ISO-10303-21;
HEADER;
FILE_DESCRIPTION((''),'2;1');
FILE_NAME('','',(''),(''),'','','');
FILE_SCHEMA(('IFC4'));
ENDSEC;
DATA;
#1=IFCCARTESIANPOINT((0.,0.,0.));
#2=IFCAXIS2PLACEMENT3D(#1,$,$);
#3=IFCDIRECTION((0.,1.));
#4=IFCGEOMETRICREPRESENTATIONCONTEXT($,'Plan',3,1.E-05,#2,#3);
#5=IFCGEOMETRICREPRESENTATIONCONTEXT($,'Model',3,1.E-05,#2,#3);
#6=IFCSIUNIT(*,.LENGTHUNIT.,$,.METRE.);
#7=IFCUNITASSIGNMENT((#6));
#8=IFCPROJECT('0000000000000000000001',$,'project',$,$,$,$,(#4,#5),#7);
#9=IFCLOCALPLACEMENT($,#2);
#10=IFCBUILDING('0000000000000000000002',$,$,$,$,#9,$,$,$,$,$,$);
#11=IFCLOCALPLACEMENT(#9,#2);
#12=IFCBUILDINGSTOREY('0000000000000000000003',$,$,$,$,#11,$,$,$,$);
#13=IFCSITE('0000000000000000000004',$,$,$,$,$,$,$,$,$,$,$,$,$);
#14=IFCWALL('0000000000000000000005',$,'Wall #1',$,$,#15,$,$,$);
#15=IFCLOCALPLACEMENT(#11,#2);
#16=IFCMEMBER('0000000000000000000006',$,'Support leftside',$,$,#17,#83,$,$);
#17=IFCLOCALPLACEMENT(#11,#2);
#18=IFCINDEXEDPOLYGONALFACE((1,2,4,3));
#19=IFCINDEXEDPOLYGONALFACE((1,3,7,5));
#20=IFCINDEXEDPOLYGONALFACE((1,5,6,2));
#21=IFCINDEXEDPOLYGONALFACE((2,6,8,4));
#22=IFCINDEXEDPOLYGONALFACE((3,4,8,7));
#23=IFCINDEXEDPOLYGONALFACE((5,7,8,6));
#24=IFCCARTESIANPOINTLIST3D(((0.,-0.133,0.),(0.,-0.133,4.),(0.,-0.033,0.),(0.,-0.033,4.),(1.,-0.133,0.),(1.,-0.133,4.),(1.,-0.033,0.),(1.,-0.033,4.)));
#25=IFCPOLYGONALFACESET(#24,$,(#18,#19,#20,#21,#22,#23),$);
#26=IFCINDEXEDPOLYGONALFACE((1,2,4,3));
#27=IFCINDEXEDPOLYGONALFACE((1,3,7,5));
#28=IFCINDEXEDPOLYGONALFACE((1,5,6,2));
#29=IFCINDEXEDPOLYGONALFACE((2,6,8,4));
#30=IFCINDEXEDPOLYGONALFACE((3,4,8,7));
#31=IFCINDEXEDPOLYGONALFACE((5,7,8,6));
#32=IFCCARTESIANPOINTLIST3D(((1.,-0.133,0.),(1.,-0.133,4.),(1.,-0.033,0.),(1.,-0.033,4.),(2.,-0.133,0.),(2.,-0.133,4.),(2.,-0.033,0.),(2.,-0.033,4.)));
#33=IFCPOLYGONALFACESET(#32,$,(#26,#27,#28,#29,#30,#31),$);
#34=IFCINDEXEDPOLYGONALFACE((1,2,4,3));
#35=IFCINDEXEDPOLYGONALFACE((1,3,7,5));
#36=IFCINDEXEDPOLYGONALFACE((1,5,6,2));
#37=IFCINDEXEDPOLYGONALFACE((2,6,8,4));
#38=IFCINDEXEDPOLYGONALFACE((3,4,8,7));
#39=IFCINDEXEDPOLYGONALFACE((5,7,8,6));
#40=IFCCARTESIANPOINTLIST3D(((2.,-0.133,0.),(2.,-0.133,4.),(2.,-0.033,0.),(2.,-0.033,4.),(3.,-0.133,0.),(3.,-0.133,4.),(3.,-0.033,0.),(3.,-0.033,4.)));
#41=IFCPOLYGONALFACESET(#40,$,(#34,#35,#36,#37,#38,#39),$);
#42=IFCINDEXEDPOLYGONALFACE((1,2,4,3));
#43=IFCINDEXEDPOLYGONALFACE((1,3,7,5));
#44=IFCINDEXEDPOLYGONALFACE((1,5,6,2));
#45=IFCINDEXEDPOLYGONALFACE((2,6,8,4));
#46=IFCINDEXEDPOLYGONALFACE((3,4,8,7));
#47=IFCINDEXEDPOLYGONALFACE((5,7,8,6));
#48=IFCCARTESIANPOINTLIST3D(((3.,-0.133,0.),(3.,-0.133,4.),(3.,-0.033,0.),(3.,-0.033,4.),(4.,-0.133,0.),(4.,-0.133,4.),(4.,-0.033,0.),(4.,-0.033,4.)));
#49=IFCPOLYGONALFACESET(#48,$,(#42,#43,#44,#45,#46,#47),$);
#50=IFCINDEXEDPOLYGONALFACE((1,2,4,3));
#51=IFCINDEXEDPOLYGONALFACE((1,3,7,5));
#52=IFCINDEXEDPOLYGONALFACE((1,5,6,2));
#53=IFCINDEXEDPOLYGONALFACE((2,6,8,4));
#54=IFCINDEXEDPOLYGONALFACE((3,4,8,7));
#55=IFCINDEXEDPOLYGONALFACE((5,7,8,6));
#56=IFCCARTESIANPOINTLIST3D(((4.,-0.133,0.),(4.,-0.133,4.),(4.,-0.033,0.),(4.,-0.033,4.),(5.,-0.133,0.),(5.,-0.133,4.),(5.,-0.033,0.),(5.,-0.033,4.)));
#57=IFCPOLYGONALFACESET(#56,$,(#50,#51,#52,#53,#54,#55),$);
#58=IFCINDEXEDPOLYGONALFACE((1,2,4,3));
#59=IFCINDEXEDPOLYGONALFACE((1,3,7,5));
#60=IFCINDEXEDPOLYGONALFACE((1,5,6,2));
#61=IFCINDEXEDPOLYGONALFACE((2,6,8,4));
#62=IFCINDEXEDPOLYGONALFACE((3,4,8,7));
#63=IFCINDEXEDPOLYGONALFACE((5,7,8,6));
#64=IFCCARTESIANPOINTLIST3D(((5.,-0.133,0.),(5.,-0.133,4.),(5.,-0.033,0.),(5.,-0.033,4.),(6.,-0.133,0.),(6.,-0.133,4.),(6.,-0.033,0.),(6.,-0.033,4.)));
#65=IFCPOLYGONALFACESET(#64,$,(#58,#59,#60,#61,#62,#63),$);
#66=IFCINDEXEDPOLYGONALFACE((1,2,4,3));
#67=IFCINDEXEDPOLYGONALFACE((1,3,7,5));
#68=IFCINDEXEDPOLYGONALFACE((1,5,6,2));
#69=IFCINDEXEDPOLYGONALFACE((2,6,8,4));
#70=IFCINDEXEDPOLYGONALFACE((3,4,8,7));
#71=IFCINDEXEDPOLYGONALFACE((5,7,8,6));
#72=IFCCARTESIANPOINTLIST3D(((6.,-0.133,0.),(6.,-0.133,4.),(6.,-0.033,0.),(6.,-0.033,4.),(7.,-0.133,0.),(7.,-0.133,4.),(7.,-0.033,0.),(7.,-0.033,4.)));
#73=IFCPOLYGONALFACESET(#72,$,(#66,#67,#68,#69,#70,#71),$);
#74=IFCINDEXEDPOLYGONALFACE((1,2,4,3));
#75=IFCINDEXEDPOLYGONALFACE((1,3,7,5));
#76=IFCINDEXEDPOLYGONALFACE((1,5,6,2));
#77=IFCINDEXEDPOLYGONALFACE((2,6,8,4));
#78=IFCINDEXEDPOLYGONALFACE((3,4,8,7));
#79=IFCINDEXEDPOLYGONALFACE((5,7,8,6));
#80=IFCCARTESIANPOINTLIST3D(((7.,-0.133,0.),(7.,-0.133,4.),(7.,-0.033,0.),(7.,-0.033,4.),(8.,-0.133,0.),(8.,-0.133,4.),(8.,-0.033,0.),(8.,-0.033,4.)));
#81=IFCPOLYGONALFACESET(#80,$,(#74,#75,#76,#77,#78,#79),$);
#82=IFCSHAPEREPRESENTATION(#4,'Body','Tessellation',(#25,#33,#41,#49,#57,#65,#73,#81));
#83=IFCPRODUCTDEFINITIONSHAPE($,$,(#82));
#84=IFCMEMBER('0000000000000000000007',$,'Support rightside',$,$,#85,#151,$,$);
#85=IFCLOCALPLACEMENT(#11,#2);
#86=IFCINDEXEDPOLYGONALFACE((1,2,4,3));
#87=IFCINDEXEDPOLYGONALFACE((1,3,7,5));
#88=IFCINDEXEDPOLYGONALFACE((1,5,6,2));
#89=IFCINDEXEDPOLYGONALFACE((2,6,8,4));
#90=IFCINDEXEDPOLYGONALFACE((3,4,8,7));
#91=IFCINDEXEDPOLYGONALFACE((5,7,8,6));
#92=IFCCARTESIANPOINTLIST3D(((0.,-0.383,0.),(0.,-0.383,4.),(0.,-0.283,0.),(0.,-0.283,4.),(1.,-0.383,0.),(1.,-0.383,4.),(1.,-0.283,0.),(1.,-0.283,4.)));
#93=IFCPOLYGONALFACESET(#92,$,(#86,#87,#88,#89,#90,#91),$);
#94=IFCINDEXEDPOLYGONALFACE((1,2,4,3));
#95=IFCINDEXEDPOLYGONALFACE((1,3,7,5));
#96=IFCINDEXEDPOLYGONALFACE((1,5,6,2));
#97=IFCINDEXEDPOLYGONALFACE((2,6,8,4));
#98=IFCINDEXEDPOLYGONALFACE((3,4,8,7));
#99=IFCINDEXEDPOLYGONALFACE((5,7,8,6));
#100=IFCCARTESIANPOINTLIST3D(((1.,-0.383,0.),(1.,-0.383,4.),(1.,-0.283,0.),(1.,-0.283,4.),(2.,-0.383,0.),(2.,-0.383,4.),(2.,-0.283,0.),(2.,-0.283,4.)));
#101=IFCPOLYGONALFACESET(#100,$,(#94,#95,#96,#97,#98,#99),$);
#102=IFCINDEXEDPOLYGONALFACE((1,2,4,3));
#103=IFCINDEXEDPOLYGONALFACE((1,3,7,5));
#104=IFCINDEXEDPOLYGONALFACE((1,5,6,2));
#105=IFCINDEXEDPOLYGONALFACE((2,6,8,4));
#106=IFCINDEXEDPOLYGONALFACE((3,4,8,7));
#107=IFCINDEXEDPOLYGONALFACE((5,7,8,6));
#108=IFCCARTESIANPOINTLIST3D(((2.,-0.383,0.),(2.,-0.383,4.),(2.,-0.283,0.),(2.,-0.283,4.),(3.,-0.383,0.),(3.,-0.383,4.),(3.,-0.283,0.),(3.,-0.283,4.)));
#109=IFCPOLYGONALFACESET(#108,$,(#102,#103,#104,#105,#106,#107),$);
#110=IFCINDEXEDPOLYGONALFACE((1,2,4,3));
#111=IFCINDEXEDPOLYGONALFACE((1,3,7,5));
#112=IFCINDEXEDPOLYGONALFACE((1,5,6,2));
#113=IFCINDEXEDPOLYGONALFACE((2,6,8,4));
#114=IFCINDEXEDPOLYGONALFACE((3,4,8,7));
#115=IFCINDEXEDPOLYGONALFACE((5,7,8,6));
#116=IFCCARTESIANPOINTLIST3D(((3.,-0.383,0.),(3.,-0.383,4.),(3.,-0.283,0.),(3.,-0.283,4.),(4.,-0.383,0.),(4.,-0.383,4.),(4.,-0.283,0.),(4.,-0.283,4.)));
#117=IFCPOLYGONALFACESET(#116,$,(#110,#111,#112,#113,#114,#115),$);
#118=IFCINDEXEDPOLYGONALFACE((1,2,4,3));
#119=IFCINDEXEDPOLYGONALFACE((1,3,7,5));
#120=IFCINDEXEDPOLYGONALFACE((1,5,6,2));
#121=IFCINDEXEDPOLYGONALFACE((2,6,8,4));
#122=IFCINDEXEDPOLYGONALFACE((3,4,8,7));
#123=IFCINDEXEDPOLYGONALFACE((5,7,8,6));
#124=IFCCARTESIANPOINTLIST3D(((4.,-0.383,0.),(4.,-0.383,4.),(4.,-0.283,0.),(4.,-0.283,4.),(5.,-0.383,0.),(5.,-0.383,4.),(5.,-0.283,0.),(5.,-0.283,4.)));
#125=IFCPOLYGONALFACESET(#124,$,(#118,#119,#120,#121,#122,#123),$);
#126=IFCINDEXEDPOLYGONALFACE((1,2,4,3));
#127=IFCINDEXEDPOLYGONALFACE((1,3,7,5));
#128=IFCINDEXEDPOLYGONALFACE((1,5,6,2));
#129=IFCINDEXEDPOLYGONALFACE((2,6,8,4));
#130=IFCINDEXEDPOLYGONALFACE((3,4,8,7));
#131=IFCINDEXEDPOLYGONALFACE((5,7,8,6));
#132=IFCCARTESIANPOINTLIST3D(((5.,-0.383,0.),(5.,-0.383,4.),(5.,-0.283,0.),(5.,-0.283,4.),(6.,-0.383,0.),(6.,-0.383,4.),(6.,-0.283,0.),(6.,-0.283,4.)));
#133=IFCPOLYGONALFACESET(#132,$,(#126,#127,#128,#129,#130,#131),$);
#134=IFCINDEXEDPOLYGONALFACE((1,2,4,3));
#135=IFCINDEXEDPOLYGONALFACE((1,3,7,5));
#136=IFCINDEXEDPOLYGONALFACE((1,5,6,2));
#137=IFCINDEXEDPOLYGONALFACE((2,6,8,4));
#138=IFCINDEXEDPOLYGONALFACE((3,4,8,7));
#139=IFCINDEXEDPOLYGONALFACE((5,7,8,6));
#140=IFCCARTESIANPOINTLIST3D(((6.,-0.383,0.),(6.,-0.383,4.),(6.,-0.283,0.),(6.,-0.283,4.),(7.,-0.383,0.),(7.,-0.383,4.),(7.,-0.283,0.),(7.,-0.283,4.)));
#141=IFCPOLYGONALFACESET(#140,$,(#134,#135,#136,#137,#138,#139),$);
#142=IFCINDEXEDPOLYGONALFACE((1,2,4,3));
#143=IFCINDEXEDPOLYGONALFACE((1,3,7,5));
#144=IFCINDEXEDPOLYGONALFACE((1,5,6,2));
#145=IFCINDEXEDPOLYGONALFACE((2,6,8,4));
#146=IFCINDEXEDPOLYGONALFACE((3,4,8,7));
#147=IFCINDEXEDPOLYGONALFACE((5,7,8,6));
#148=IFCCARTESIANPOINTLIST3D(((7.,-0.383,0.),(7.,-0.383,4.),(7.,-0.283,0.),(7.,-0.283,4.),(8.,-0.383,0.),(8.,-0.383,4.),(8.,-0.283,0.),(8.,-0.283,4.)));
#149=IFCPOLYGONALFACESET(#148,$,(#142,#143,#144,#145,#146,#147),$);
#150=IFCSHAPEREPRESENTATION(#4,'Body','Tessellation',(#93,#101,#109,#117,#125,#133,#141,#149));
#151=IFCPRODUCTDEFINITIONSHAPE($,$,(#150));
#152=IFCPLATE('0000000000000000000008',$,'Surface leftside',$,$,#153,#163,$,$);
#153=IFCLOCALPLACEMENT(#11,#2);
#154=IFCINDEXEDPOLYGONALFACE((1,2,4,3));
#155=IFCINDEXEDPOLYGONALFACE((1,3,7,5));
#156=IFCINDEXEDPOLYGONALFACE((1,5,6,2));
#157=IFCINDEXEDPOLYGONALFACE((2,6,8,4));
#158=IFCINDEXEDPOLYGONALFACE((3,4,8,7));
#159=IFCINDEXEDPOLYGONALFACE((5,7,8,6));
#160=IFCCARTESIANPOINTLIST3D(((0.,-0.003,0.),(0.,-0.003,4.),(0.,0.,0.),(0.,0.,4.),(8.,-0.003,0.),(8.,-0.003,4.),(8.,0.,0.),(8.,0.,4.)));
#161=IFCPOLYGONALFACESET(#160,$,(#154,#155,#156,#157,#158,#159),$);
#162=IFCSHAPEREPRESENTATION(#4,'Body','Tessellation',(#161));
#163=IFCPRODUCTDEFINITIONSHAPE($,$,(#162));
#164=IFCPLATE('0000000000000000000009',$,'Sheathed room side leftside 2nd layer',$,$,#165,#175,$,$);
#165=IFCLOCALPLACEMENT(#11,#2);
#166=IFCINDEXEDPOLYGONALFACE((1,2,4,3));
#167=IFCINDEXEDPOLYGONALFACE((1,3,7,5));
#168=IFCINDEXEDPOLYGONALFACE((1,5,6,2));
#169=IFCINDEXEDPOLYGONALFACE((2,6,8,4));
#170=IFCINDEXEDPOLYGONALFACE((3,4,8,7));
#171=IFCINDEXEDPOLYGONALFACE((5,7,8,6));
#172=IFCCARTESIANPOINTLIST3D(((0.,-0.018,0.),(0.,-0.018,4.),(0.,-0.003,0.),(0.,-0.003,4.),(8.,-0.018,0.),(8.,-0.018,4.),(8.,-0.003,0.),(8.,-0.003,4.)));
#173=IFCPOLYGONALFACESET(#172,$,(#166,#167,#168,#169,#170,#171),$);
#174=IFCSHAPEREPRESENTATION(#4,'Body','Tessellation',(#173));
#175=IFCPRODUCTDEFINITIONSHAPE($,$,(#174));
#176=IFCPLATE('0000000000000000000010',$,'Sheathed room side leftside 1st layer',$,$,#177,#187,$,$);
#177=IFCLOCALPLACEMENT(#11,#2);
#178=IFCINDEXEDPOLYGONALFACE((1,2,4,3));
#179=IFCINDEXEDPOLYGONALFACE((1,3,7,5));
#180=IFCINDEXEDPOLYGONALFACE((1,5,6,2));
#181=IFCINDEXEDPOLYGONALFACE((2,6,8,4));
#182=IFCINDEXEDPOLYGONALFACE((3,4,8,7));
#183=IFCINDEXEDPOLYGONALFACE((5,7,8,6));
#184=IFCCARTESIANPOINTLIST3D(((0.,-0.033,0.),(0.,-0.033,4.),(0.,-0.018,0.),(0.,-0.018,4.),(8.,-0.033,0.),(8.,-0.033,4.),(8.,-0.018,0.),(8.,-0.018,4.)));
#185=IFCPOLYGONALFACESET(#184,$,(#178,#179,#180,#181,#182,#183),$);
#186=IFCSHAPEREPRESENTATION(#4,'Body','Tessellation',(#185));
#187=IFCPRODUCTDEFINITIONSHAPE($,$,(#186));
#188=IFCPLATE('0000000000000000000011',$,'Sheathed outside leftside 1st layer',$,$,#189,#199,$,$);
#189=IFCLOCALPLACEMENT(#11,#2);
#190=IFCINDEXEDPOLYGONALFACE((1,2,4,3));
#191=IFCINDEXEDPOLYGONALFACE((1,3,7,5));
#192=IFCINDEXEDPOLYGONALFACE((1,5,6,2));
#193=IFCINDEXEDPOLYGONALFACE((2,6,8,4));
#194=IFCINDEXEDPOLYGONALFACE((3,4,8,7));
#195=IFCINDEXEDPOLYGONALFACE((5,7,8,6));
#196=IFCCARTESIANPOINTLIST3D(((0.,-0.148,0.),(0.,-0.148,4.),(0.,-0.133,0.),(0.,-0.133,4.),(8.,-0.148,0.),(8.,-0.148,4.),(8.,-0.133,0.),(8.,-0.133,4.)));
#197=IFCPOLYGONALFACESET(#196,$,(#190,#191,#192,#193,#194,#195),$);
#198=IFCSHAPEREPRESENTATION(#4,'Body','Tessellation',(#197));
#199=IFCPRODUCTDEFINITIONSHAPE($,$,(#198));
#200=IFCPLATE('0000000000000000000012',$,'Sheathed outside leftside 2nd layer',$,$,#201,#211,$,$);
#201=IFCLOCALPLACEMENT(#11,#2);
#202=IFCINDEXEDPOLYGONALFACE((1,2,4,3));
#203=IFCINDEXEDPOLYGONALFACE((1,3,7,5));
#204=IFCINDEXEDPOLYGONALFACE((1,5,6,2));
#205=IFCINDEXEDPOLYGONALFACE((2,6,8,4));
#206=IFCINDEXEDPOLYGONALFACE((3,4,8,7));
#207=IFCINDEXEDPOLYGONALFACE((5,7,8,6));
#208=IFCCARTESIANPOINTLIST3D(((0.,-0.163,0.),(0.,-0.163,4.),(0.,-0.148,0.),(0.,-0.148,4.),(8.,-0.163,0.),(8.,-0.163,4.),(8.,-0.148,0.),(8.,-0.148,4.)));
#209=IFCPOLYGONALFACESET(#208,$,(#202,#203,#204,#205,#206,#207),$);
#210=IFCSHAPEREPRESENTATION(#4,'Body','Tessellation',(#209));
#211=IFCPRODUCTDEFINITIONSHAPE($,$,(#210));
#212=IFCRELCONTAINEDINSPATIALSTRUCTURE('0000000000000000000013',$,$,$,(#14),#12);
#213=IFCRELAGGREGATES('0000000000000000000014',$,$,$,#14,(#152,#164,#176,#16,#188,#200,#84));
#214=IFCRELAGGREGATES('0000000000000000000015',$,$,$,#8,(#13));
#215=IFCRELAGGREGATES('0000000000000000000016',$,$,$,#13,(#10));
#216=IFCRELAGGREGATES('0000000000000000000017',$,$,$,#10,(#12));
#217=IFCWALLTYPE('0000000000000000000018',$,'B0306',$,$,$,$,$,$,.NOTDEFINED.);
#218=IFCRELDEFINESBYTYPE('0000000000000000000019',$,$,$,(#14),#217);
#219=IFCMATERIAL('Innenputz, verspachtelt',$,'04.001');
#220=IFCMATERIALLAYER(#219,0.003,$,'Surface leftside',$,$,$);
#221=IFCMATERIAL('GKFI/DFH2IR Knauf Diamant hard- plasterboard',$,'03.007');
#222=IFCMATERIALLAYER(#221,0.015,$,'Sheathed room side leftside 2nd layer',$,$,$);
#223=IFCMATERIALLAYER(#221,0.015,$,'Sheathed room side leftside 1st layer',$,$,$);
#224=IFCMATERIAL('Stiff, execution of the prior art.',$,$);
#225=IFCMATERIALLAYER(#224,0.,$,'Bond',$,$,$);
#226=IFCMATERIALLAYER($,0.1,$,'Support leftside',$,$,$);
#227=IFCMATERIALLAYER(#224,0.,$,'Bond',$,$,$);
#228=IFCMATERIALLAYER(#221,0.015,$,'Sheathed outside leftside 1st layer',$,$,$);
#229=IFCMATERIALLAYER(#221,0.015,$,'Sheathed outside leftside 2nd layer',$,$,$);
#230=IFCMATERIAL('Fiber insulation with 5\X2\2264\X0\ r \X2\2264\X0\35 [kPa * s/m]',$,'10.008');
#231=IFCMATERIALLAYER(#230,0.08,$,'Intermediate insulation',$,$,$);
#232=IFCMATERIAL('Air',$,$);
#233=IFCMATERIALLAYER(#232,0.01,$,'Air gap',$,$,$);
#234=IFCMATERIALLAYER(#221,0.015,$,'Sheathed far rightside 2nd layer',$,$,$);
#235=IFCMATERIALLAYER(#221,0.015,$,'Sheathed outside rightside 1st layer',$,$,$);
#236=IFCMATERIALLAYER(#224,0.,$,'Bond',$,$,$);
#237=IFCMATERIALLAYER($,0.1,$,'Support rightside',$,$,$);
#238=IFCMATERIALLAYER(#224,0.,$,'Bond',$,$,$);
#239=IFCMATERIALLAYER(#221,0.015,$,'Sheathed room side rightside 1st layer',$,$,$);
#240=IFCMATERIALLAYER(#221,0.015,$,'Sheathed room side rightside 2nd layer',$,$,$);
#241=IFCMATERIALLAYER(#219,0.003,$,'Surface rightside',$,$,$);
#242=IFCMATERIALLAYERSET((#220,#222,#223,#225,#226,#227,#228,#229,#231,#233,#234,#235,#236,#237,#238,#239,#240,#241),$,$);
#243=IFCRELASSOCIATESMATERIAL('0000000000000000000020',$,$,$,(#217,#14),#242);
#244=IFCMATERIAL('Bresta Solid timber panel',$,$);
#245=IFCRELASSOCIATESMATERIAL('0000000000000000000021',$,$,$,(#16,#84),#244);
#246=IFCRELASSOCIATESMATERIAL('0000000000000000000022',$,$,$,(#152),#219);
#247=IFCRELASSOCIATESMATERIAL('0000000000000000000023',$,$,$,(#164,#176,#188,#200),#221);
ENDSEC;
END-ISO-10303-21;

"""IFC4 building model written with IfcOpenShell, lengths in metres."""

from ifc_helpers import new_model, si_unit, direction, frame, frame_2d, origin, origin_with_axes, place, context, project, spatial, rectangle, extrude, material, layer, layer_set, type_object, element, aggregate, save


model = new_model("IFC4")

# Units and contexts
plan_context = context("Plan", 3, precision=1e-05, world=origin(), true_north=direction((0.0, 1.0)))
model_context = context("Model", 3, precision=1e-05, world=origin(), true_north=direction((0.0, 1.0)))
ifc_project = project(units=[si_unit("LENGTHUNIT", "METRE")], contexts=[plan_context, model_context])

# Site, building, storey
site = spatial("IfcSite", under=ifc_project)
building_placement = place(None, origin())
building = spatial("IfcBuilding", under=site, at=building_placement)
storey_placement = place(building_placement, origin())
storey = spatial("IfcBuildingStorey", under=building, at=storey_placement)

# Wall, members, plates
ifc_material_1 = material(Name="Innenputz, verspachtelt", Category="04.001")
ifc_layer_1 = layer(ifc_material_1, 0.003, Name="Surface leftside")
ifc_material_2 = material(Name="GKFI/DFH2IR Knauf Diamant hard- plasterboard", Category="03.007")
ifc_layer_2 = layer(ifc_material_2, 0.015, Name="Sheathed room side leftside 2nd layer")
ifc_layer_3 = layer(ifc_material_2, 0.015, Name="Sheathed room side leftside 1st layer")
ifc_material_3 = material(Name="Stiff, execution of the prior art.")
ifc_layer_4 = layer(ifc_material_3, 0.0, Name="Bond")
ifc_layer_5 = layer(None, 0.1, Name="Support leftside")
ifc_layer_6 = layer(ifc_material_3, 0.0, Name="Bond")
ifc_layer_7 = layer(ifc_material_2, 0.015, Name="Sheathed outside leftside 1st layer")
ifc_layer_8 = layer(ifc_material_2, 0.015, Name="Sheathed outside leftside 2nd layer")
ifc_material_4 = material(Name="Fiber insulation with 5≤ r ≤35 [kPa * s/m]", Category="10.008")
ifc_layer_9 = layer(ifc_material_4, 0.08, Name="Intermediate insulation")
ifc_material_5 = material(Name="Air")
ifc_layer_10 = layer(ifc_material_5, 0.01, Name="Air gap")
ifc_layer_11 = layer(ifc_material_2, 0.015, Name="Sheathed far rightside 2nd layer")
ifc_layer_12 = layer(ifc_material_2, 0.015, Name="Sheathed outside rightside 1st layer")
ifc_layer_13 = layer(ifc_material_3, 0.0, Name="Bond")
ifc_layer_14 = layer(None, 0.1, Name="Support rightside")
ifc_layer_15 = layer(ifc_material_3, 0.0, Name="Bond")
ifc_layer_16 = layer(ifc_material_2, 0.015, Name="Sheathed room side rightside 1st layer")
ifc_layer_17 = layer(ifc_material_2, 0.015, Name="Sheathed room side rightside 2nd layer")
ifc_layer_18 = layer(ifc_material_1, 0.003, Name="Surface rightside")
ifc_layer_set = layer_set([ifc_layer_1, ifc_layer_2, ifc_layer_3, ifc_layer_4, ifc_layer_5, ifc_layer_6, ifc_layer_7, ifc_layer_8, ifc_layer_9, ifc_layer_10, ifc_layer_11, ifc_layer_12, ifc_layer_13, ifc_layer_14, ifc_layer_15, ifc_layer_16, ifc_layer_17, ifc_layer_18])
wall_type = type_object("IfcWallType", Name="B0306", PredefinedType="NOTDEFINED", material=ifc_layer_set)
wall_placement = place(None, frame((0.0, 0.0, 0.0), z_axis=(0.0, -1.0, 0.0), x_axis=(1.0, 0.0, 0.0)))
wall = element("IfcWall", 1, at=wall_placement, inside=storey, type_object=wall_type, material=ifc_layer_set, Name="Wall #1")
ifc_material_6 = material(Name="Bresta Solid timber panel")
member_1_placement = place(wall_placement, origin())
member_1 = element("IfcMember", 2, at=member_1_placement, material=ifc_material_6, Name="Support leftside", context=plan_context, shape_type="SweptSolid", body=[
    extrude(rectangle(XDim=1.0, YDim=0.1, at=frame_2d((0.5, 0.05), x_axis=(1.0, 0.0))), frame((0.0, 4.0, 0.033), z_axis=(0.0, -1.0, 0.0), x_axis=(1.0, 0.0, 0.0)), (0.0, 0.0, 1.0), 4.0),
    extrude(rectangle(XDim=1.0, YDim=0.1, at=frame_2d((0.5, 0.05), x_axis=(1.0, 0.0))), frame((1.0, 4.0, 0.033), z_axis=(0.0, -1.0, 0.0), x_axis=(1.0, 0.0, 0.0)), (0.0, 0.0, 1.0), 4.0),
    extrude(rectangle(XDim=1.0, YDim=0.1, at=frame_2d((0.5, 0.05), x_axis=(1.0, 0.0))), frame((2.0, 4.0, 0.033), z_axis=(0.0, -1.0, 0.0), x_axis=(1.0, 0.0, 0.0)), (0.0, 0.0, 1.0), 4.0),
    extrude(rectangle(XDim=1.0, YDim=0.1, at=frame_2d((0.5, 0.05), x_axis=(1.0, 0.0))), frame((3.0, 4.0, 0.033), z_axis=(0.0, -1.0, 0.0), x_axis=(1.0, 0.0, 0.0)), (0.0, 0.0, 1.0), 4.0),
    extrude(rectangle(XDim=1.0, YDim=0.1, at=frame_2d((0.5, 0.05), x_axis=(1.0, 0.0))), frame((4.0, 4.0, 0.033), z_axis=(0.0, -1.0, 0.0), x_axis=(1.0, 0.0, 0.0)), (0.0, 0.0, 1.0), 4.0),
    extrude(rectangle(XDim=1.0, YDim=0.1, at=frame_2d((0.5, 0.05), x_axis=(1.0, 0.0))), frame((5.0, 4.0, 0.033), z_axis=(0.0, -1.0, 0.0), x_axis=(1.0, 0.0, 0.0)), (0.0, 0.0, 1.0), 4.0),
    extrude(rectangle(XDim=1.0, YDim=0.1, at=frame_2d((0.5, 0.05), x_axis=(1.0, 0.0))), frame((6.0, 4.0, 0.033), z_axis=(0.0, -1.0, 0.0), x_axis=(1.0, 0.0, 0.0)), (0.0, 0.0, 1.0), 4.0),
    extrude(rectangle(XDim=1.0, YDim=0.1, at=frame_2d((0.5, 0.05), x_axis=(1.0, 0.0))), frame((7.0, 4.0, 0.033), z_axis=(0.0, -1.0, 0.0), x_axis=(1.0, 0.0, 0.0)), (0.0, 0.0, 1.0), 4.0),
])
member_2_placement = place(wall_placement, origin())
member_2 = element("IfcMember", 3, at=member_2_placement, material=ifc_material_6, Name="Support rightside", context=plan_context, shape_type="SweptSolid", body=[
    extrude(rectangle(XDim=1.0, YDim=0.1, at=frame_2d((0.5, 0.05), x_axis=(1.0, 0.0))), frame((0.0, 4.0, 0.283), z_axis=(0.0, -1.0, 0.0), x_axis=(1.0, 0.0, 0.0)), (0.0, 0.0, 1.0), 4.0),
    extrude(rectangle(XDim=1.0, YDim=0.1, at=frame_2d((0.5, 0.05), x_axis=(1.0, 0.0))), frame((1.0, 4.0, 0.283), z_axis=(0.0, -1.0, 0.0), x_axis=(1.0, 0.0, 0.0)), (0.0, 0.0, 1.0), 4.0),
    extrude(rectangle(XDim=1.0, YDim=0.1, at=frame_2d((0.5, 0.05), x_axis=(1.0, 0.0))), frame((2.0, 4.0, 0.283), z_axis=(0.0, -1.0, 0.0), x_axis=(1.0, 0.0, 0.0)), (0.0, 0.0, 1.0), 4.0),
    extrude(rectangle(XDim=1.0, YDim=0.1, at=frame_2d((0.5, 0.05), x_axis=(1.0, 0.0))), frame((3.0, 4.0, 0.283), z_axis=(0.0, -1.0, 0.0), x_axis=(1.0, 0.0, 0.0)), (0.0, 0.0, 1.0), 4.0),
    extrude(rectangle(XDim=1.0, YDim=0.1, at=frame_2d((0.5, 0.05), x_axis=(1.0, 0.0))), frame((4.0, 4.0, 0.283), z_axis=(0.0, -1.0, 0.0), x_axis=(1.0, 0.0, 0.0)), (0.0, 0.0, 1.0), 4.0),
    extrude(rectangle(XDim=1.0, YDim=0.1, at=frame_2d((0.5, 0.05), x_axis=(1.0, 0.0))), frame((5.0, 4.0, 0.283), z_axis=(0.0, -1.0, 0.0), x_axis=(1.0, 0.0, 0.0)), (0.0, 0.0, 1.0), 4.0),
    extrude(rectangle(XDim=1.0, YDim=0.1, at=frame_2d((0.5, 0.05), x_axis=(1.0, 0.0))), frame((6.0, 4.0, 0.283), z_axis=(0.0, -1.0, 0.0), x_axis=(1.0, 0.0, 0.0)), (0.0, 0.0, 1.0), 4.0),
    extrude(rectangle(XDim=1.0, YDim=0.1, at=frame_2d((0.5, 0.05), x_axis=(1.0, 0.0))), frame((7.0, 4.0, 0.283), z_axis=(0.0, -1.0, 0.0), x_axis=(1.0, 0.0, 0.0)), (0.0, 0.0, 1.0), 4.0),
])
plate_1_placement = place(wall_placement, origin())
plate_1 = element("IfcPlate", 4, at=plate_1_placement, material=ifc_material_1, Name="Surface leftside", context=plan_context, shape_type="SweptSolid", body=[
    extrude(rectangle(XDim=8.0, YDim=4.0, at=frame_2d((4.0, 2.0), x_axis=(1.0, 0.0))), origin_with_axes(), (0.0, 0.0, 1.0), 0.003),
])
plate_2_placement = place(wall_placement, origin())
plate_2 = element("IfcPlate", 5, at=plate_2_placement, material=ifc_material_2, Name="Sheathed room side leftside 2nd layer", context=plan_context, shape_type="SweptSolid", body=[
    extrude(rectangle(XDim=8.0, YDim=4.0, at=frame_2d((4.0, 2.0), x_axis=(1.0, 0.0))), frame((0.0, 0.0, 0.003), z_axis=(0.0, 0.0, 1.0), x_axis=(1.0, 0.0, 0.0)), (0.0, 0.0, 1.0), 0.015),
])
plate_3_placement = place(wall_placement, origin())
plate_3 = element("IfcPlate", 6, at=plate_3_placement, material=ifc_material_2, Name="Sheathed room side leftside 1st layer", context=plan_context, shape_type="SweptSolid", body=[
    extrude(rectangle(XDim=8.0, YDim=4.0, at=frame_2d((4.0, 2.0), x_axis=(1.0, 0.0))), frame((0.0, 0.0, 0.018), z_axis=(0.0, 0.0, 1.0), x_axis=(1.0, 0.0, 0.0)), (0.0, 0.0, 1.0), 0.015),
])
plate_4_placement = place(wall_placement, origin())
plate_4 = element("IfcPlate", 7, at=plate_4_placement, material=ifc_material_2, Name="Sheathed outside leftside 1st layer", context=plan_context, shape_type="SweptSolid", body=[
    extrude(rectangle(XDim=8.0, YDim=4.0, at=frame_2d((4.0, 2.0), x_axis=(1.0, 0.0))), frame((0.0, 0.0, 0.133), z_axis=(0.0, 0.0, 1.0), x_axis=(1.0, 0.0, 0.0)), (0.0, 0.0, 1.0), 0.015),
])
plate_5_placement = place(wall_placement, origin())
plate_5 = element("IfcPlate", 8, at=plate_5_placement, material=ifc_material_2, Name="Sheathed outside leftside 2nd layer", context=plan_context, shape_type="SweptSolid", body=[
    extrude(rectangle(XDim=8.0, YDim=4.0, at=frame_2d((4.0, 2.0), x_axis=(1.0, 0.0))), frame((0.0, 0.0, 0.148), z_axis=(0.0, 0.0, 1.0), x_axis=(1.0, 0.0, 0.0)), (0.0, 0.0, 1.0), 0.015),
])
aggregate(wall, [plate_1, plate_2, plate_3, member_1, plate_4, plate_5, member_2])

save(model, "model.ifc")
